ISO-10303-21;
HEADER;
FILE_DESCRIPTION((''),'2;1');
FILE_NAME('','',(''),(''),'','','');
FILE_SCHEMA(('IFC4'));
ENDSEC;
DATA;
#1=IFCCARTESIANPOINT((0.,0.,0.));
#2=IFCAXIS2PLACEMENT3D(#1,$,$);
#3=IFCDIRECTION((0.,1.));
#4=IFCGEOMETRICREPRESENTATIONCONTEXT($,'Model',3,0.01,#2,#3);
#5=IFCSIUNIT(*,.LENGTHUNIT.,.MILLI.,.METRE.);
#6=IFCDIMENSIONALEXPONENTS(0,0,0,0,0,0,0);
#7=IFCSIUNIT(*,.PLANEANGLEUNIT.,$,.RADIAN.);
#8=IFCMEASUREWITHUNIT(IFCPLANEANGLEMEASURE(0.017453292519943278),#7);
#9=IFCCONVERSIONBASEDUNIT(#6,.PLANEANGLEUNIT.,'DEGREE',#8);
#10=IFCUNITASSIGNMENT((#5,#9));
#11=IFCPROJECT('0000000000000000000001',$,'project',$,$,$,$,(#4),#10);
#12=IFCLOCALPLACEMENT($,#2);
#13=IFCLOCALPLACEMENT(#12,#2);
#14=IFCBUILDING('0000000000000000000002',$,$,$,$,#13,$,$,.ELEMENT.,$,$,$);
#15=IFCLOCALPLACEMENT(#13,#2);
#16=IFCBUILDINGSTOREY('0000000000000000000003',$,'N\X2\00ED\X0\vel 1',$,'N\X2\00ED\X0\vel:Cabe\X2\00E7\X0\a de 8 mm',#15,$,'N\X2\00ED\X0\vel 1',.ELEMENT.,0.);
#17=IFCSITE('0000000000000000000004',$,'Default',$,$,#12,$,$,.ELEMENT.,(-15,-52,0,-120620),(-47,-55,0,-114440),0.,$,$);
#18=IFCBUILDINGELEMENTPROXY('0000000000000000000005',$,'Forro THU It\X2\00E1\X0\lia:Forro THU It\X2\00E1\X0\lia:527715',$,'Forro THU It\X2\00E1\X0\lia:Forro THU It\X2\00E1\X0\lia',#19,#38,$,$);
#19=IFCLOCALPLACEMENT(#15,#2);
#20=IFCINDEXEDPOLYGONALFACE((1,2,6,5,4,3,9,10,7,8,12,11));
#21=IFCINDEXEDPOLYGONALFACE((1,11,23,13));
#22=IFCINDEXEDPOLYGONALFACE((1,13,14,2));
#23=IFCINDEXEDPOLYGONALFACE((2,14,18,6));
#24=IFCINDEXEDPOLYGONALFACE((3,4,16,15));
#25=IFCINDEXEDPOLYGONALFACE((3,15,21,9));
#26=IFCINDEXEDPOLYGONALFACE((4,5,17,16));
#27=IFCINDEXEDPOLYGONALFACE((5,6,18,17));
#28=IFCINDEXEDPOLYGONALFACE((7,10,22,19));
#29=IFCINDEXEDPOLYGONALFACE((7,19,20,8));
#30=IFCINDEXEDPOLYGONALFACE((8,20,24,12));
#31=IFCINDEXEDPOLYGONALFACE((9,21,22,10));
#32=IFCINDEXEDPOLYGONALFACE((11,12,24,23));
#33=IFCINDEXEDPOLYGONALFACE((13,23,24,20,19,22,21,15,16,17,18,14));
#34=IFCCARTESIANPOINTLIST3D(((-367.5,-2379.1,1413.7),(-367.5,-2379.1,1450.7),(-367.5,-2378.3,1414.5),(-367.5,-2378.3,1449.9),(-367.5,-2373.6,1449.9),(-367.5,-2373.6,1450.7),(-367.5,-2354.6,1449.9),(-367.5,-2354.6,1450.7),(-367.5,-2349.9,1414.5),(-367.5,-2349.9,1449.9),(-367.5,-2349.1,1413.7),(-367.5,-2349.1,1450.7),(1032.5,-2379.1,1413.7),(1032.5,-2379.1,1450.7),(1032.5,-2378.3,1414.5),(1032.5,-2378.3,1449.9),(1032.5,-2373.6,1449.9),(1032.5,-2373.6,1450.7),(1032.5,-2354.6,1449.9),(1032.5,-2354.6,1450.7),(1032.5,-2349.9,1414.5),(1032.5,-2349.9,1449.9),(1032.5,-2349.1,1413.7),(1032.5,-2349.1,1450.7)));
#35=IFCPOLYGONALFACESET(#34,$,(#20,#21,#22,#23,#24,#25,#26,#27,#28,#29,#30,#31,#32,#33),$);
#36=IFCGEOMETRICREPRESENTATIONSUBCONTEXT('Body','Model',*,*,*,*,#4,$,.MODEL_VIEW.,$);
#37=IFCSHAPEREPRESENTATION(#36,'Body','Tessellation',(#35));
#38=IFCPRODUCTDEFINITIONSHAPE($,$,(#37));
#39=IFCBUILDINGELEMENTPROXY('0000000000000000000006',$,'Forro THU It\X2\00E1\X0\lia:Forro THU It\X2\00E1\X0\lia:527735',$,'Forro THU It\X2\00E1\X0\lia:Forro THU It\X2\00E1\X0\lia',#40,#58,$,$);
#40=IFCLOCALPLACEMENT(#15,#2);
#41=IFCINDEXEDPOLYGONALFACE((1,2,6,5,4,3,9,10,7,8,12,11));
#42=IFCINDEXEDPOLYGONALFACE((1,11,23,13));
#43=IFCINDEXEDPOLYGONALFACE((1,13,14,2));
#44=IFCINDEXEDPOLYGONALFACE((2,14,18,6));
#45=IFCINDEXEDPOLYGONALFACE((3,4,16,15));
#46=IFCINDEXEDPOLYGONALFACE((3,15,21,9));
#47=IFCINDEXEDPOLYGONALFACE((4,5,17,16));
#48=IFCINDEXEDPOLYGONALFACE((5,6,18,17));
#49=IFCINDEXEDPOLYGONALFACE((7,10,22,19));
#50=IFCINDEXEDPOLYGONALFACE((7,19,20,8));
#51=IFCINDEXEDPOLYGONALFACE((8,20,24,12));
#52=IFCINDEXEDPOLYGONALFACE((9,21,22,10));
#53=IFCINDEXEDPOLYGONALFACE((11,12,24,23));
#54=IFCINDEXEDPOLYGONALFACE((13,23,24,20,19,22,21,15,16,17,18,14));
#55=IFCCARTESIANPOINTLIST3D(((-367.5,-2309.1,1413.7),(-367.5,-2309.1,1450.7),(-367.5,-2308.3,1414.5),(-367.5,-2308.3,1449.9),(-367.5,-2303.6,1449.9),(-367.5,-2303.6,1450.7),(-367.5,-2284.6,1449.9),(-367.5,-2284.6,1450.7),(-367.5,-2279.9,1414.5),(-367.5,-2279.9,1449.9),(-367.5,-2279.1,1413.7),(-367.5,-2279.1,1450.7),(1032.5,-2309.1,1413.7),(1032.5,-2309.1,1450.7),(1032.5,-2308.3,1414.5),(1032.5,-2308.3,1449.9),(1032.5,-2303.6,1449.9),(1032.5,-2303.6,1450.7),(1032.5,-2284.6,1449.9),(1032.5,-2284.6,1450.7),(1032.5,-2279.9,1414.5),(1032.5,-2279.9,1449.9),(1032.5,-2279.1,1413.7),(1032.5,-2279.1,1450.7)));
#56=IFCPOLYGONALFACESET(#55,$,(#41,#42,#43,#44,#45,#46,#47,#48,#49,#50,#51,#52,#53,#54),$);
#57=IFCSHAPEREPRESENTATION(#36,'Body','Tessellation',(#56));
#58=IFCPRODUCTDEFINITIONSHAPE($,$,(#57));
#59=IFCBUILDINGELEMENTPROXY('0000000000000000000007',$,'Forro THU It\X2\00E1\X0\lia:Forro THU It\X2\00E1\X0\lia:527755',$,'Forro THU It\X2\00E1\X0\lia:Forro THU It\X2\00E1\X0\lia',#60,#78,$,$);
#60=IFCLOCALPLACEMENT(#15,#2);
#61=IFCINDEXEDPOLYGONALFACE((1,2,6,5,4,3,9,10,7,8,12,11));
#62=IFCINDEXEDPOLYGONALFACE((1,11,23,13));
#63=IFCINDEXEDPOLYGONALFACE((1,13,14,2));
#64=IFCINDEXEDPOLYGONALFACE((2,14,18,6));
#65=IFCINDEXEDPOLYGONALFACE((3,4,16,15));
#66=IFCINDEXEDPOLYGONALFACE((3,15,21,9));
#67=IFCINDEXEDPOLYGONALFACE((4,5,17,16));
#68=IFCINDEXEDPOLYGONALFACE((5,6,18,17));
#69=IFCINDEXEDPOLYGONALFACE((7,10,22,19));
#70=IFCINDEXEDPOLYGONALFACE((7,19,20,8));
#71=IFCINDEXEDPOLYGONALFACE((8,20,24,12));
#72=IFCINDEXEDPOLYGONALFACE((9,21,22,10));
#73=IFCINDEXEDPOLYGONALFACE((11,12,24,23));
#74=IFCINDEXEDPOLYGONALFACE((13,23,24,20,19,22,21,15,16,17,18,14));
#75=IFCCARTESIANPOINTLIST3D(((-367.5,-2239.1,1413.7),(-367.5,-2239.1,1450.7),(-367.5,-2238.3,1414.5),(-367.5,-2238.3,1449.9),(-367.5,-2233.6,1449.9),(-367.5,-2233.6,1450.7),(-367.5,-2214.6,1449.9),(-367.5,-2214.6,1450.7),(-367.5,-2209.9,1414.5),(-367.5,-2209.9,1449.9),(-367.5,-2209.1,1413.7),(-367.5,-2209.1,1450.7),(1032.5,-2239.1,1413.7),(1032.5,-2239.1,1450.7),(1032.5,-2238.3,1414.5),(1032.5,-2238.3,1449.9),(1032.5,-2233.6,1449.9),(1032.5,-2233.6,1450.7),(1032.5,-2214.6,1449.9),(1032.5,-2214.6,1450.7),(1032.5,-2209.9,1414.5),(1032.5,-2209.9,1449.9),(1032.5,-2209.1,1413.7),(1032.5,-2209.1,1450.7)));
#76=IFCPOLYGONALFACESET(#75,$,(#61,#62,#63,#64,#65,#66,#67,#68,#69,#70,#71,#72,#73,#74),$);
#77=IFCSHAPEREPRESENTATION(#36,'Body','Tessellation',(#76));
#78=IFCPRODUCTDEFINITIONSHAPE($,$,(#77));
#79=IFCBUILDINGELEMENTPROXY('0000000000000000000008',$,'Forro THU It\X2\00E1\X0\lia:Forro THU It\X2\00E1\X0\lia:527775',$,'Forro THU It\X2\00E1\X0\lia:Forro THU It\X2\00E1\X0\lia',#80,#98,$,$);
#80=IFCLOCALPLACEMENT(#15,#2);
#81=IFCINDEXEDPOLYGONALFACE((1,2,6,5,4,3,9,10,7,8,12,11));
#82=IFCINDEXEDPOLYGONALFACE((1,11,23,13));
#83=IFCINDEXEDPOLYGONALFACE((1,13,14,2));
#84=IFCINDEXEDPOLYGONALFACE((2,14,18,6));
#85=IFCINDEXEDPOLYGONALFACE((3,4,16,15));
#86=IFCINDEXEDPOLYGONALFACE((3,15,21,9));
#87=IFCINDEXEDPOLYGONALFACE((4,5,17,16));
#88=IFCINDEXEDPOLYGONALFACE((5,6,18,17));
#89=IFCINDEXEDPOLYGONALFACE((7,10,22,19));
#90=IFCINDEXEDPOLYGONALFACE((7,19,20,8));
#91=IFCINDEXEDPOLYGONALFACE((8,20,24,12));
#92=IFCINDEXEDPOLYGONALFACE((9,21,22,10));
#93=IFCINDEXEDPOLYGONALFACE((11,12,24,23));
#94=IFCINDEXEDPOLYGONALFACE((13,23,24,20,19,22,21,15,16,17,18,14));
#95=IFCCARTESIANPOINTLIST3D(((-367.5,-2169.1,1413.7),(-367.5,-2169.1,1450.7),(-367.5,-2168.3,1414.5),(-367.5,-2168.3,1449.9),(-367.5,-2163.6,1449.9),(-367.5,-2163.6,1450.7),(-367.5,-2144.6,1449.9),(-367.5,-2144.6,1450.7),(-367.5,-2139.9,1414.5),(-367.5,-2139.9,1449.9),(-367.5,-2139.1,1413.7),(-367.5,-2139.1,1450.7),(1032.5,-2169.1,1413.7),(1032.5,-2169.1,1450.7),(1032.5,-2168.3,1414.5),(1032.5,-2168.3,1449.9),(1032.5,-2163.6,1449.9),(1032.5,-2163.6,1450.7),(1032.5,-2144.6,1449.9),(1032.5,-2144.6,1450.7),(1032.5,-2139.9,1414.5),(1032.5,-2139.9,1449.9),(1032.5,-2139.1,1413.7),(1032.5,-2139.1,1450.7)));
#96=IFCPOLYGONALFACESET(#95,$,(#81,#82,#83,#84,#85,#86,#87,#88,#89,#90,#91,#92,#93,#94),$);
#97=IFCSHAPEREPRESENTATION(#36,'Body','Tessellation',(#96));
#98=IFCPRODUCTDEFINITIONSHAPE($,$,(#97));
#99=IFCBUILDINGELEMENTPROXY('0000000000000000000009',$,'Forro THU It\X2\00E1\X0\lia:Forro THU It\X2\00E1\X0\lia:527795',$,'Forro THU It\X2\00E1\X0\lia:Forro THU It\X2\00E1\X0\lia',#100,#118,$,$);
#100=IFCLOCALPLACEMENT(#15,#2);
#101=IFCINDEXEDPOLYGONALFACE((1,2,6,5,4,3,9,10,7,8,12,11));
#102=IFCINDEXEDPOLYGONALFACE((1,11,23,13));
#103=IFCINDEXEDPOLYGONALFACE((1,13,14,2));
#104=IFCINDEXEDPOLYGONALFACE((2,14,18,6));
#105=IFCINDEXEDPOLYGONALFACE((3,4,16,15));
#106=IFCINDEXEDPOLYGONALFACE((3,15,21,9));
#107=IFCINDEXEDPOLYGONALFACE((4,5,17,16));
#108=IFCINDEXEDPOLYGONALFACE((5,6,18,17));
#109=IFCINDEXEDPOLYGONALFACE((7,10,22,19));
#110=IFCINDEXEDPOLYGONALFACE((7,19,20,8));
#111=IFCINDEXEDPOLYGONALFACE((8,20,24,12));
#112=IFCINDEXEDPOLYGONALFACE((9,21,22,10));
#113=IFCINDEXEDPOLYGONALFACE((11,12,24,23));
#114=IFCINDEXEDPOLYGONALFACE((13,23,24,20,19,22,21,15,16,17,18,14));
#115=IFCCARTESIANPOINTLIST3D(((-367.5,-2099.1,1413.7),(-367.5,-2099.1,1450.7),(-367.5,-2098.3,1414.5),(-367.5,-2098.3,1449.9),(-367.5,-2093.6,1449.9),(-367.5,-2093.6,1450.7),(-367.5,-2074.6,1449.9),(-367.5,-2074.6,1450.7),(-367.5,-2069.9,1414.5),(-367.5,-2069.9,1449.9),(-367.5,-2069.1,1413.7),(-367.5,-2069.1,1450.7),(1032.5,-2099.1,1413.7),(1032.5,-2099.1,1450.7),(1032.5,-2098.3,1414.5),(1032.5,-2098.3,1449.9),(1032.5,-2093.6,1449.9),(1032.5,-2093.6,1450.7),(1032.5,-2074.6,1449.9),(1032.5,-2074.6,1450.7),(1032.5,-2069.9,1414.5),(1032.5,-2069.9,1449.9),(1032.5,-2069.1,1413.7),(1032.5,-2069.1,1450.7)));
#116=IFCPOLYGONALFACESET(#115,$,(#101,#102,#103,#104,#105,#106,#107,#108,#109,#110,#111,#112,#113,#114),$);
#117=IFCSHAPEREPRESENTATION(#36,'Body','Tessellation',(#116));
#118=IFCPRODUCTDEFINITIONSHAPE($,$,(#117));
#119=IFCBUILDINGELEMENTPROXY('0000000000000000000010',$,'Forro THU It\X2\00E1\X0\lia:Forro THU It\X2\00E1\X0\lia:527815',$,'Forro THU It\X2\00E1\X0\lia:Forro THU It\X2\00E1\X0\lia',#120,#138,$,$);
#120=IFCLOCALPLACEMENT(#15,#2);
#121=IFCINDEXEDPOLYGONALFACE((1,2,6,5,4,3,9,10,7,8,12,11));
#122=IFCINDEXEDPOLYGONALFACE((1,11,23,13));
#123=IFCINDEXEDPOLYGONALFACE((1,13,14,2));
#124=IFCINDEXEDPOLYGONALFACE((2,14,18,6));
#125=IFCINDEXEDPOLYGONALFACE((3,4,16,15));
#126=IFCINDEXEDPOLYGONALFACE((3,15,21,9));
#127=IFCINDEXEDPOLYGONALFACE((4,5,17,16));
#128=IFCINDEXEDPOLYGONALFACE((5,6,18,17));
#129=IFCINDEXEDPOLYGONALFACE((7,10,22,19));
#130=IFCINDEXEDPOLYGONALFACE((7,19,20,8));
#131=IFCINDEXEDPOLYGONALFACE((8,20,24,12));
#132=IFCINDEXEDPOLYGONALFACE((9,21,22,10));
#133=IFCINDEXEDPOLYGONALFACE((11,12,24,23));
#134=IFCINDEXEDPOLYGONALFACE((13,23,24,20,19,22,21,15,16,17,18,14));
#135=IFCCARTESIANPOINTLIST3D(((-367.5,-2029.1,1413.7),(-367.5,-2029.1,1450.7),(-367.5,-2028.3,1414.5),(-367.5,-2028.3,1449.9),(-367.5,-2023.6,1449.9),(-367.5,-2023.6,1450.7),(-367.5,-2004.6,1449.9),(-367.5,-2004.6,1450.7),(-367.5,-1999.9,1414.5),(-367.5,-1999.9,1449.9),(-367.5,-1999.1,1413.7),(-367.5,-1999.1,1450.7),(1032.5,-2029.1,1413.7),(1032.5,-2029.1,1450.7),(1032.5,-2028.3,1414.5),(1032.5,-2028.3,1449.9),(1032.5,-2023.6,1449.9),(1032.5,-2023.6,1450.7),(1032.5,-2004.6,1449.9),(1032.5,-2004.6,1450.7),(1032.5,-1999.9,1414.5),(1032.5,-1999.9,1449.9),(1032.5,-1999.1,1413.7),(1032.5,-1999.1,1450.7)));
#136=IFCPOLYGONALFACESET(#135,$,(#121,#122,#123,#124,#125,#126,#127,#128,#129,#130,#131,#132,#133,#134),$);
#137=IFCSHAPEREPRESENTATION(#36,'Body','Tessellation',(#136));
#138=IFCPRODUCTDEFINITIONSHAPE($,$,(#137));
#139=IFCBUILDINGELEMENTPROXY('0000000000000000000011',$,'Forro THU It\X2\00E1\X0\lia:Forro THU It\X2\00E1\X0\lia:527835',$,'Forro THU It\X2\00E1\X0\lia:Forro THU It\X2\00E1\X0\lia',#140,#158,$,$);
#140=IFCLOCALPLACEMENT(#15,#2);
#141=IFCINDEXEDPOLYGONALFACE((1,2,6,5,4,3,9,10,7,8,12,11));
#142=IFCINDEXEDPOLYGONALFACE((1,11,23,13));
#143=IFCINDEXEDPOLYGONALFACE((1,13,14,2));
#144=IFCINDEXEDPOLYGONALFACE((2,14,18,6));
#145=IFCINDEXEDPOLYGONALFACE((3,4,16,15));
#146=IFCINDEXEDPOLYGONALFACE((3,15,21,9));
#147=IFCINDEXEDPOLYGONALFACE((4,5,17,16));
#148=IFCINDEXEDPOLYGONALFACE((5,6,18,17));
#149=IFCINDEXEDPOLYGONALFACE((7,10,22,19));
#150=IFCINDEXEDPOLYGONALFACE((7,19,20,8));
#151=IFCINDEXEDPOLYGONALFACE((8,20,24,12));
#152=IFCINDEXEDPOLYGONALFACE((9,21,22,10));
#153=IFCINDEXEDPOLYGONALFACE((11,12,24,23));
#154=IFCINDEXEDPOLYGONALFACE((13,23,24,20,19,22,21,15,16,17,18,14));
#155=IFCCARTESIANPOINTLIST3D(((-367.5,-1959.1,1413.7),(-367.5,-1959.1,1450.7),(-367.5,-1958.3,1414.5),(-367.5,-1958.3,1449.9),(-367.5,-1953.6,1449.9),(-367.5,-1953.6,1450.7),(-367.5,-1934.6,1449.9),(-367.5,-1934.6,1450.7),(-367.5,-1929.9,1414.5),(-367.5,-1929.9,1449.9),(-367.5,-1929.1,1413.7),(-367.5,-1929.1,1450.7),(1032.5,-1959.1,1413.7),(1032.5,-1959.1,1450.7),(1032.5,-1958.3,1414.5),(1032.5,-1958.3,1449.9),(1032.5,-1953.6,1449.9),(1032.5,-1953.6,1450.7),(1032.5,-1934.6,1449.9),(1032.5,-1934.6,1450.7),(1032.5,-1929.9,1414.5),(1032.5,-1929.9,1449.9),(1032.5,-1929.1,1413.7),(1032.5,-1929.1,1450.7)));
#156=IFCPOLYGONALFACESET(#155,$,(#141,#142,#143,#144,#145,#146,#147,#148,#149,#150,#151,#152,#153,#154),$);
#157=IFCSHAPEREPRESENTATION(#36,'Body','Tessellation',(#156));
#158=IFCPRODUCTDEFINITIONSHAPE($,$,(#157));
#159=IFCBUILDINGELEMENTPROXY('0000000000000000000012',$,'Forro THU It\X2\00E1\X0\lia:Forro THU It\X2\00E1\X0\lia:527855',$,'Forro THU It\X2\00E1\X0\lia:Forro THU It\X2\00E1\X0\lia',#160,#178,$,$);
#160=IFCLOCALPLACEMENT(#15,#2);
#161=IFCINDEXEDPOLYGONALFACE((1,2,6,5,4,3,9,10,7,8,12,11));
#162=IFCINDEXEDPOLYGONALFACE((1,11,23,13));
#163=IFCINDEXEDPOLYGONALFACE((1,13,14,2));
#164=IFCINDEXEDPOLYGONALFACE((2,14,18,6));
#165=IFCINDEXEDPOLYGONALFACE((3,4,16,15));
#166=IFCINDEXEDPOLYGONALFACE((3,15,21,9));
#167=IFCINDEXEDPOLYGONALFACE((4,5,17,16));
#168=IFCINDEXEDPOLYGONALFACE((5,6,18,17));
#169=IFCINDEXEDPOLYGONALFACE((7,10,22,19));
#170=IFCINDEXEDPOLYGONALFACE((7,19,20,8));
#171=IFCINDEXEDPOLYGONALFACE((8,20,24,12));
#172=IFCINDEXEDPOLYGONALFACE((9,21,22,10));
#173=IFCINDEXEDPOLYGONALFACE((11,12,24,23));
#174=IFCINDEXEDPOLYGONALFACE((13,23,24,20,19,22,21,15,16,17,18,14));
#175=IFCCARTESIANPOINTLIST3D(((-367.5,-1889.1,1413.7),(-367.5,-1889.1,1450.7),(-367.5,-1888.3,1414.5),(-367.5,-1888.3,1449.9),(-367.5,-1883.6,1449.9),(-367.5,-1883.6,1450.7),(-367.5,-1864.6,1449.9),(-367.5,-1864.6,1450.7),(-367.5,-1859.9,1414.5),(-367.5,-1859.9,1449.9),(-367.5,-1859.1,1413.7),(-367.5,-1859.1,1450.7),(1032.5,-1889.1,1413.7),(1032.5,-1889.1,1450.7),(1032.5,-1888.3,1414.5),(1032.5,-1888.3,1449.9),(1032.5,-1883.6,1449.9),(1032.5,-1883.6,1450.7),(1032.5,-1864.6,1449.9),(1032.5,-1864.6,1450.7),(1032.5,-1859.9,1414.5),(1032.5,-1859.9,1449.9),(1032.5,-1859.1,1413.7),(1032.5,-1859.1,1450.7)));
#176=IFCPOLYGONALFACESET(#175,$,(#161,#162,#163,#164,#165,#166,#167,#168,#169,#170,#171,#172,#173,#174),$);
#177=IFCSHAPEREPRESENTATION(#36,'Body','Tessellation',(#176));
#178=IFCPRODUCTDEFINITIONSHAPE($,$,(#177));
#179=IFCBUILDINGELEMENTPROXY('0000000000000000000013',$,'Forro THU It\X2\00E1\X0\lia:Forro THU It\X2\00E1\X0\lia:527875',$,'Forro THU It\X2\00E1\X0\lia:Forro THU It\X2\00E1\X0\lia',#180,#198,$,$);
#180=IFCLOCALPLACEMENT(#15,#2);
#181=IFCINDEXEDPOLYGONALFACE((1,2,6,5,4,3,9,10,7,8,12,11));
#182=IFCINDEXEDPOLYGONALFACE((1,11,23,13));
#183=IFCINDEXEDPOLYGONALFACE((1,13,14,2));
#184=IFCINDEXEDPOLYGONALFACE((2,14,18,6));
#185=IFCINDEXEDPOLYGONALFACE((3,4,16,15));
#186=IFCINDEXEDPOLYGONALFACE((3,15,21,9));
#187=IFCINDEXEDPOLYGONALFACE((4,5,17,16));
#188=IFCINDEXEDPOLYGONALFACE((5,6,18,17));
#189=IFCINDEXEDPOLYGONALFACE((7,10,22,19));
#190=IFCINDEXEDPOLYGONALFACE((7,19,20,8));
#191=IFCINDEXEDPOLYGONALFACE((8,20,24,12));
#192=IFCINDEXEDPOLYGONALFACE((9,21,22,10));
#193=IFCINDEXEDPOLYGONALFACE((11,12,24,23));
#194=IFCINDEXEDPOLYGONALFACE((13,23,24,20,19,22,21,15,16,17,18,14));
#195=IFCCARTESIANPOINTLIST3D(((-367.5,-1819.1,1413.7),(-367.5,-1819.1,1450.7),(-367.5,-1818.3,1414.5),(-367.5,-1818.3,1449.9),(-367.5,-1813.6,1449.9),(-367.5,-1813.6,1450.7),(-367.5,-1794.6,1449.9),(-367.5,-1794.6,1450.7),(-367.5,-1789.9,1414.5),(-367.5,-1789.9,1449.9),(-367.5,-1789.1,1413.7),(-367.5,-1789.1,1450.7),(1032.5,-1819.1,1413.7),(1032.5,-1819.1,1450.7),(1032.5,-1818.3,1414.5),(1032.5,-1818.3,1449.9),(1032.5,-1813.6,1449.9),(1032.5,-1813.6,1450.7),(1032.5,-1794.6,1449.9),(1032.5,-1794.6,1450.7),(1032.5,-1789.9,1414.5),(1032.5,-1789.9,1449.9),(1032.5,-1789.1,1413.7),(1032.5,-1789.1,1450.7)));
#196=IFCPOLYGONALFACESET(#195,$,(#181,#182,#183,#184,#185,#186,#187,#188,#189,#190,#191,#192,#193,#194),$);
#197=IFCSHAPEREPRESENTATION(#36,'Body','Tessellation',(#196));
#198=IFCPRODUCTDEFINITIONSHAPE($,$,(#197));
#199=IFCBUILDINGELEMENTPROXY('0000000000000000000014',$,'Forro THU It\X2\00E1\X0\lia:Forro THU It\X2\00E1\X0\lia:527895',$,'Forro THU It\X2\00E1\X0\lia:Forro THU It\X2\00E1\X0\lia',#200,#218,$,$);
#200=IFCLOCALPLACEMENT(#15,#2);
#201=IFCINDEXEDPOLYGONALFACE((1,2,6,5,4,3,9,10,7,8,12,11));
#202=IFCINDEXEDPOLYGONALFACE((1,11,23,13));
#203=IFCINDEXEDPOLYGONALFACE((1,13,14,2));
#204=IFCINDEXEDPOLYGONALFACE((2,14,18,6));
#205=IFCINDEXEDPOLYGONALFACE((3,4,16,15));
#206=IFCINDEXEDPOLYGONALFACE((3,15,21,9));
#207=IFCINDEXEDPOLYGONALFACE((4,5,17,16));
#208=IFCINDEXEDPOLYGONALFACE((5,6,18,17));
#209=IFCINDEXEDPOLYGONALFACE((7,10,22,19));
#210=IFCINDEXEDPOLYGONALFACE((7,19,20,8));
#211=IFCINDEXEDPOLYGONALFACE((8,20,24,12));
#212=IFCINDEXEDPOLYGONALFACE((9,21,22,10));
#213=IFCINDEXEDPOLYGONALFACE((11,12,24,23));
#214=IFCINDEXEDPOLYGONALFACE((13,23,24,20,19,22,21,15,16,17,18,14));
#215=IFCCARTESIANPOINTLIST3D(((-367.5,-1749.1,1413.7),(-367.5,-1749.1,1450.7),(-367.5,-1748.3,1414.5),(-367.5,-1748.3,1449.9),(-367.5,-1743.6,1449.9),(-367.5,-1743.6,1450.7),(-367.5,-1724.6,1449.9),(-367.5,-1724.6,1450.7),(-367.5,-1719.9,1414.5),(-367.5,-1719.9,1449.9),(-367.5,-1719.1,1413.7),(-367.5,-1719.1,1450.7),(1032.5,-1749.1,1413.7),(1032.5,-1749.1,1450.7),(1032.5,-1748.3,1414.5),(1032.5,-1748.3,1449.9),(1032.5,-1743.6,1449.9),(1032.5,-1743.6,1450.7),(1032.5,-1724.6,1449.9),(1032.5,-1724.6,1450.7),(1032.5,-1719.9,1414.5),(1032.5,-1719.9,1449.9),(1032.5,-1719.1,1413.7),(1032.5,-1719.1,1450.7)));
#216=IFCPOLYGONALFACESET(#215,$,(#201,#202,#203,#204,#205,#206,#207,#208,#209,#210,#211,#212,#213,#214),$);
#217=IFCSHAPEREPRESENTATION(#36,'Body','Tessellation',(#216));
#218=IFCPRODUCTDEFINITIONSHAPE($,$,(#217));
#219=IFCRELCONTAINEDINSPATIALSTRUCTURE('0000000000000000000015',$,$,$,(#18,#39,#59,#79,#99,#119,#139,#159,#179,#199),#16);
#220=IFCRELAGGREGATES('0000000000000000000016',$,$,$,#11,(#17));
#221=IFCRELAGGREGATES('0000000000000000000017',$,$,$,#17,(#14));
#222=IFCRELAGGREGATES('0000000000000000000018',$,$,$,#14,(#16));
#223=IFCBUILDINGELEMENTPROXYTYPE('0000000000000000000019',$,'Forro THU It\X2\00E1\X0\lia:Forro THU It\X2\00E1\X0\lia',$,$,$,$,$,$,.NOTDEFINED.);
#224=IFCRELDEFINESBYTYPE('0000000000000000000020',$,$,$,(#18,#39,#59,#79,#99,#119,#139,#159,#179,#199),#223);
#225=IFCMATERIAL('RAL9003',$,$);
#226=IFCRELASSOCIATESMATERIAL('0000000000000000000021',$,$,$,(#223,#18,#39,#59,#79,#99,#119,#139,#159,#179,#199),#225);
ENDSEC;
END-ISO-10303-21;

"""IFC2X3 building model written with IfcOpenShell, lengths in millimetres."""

from ifc_helpers import new_model, entity, si_unit, converted_unit, direction, frame, origin, place, context, subcontext, project, spatial, polyline, outline, extrude, source, transform, mapped, material, type_object, type_shapes, element, save


model = new_model("IFC2X3")

# Units and contexts
model_context = context("Model", 3, precision=0.01, world=origin(), true_north=direction((0.0, 1.0)))
body_context = subcontext(model_context, "Body", "Model", "MODEL_VIEW")
ifc_project = project(units=[si_unit("LENGTHUNIT", "METRE", prefix="MILLI"), converted_unit("PLANEANGLEUNIT", "DEGREE", entity("IfcPlaneAngleMeasure", 0.017453292519943278), si_unit("PLANEANGLEUNIT", "RADIAN"), dimensions=[0, 0, 0, 0, 0, 0, 0])], contexts=[model_context])

# Site, building, storey
site_placement = place(None, origin())
site = spatial("IfcSite", under=ifc_project, at=site_placement, Name="Default", CompositionType="ELEMENT", RefLatitude=(-15, -52, 0, -120620), RefLongitude=(-47, -55, 0, -114440), RefElevation=0.0)
building_placement = place(site_placement, origin())
building = spatial("IfcBuilding", under=site, at=building_placement, CompositionType="ELEMENT")
storey_placement = place(building_placement, origin())
storey = spatial("IfcBuildingStorey", under=building, at=storey_placement, Name="Nível 1", ObjectType="Nível:Cabeça de 8 mm", LongName="Nível 1", CompositionType="ELEMENT", Elevation=0.0)

# Building element proxies
ifc_material_1 = material(Name="RAL9003")
building_element_proxy_type = type_object("IfcBuildingElementProxyType", Name="Forro THU Itália:Forro THU Itália", PredefinedType="NOTDEFINED", material=ifc_material_1)
shared_shape_1 = source(origin(), body_context, "Body", "SweptSolid", [
    extrude(outline(polyline([(-12.5, -15.0), (24.5, -15.0), (24.5, 15.0), (-12.5, 15.0), (-12.5, 9.5), (-11.7, 9.5), (-11.7, 14.2), (23.7, 14.2), (23.7, -14.2), (-11.7, -14.2), (-11.7, -9.5), (-12.5, -9.5), (-12.5, -15.0)])), frame((0.0, 15.0, -12.5), z_axis=(1.0, 0.0, 0.0), x_axis=(0.0, 0.0, -1.0)), (0.0, 0.0, 1.0), 1400.0),
])
type_shapes(building_element_proxy_type, [shared_shape_1])
for number, where, name in (
    (1, (-367.5, -2379.1, 1450.7), "Forro THU Itália:Forro THU Itália:527715"),
    (2, (-367.5, -2309.1, 1450.7), "Forro THU Itália:Forro THU Itália:527735"),
    (3, (-367.5, -2239.1, 1450.7), "Forro THU Itália:Forro THU Itália:527755"),
    (4, (-367.5, -2169.1, 1450.7), "Forro THU Itália:Forro THU Itália:527775"),
    (5, (-367.5, -2099.1, 1450.7), "Forro THU Itália:Forro THU Itália:527795"),
    (6, (-367.5, -2029.1, 1450.7), "Forro THU Itália:Forro THU Itália:527815"),
    (7, (-367.5, -1959.1, 1450.7), "Forro THU Itália:Forro THU Itália:527835"),
    (8, (-367.5, -1889.1, 1450.7), "Forro THU Itália:Forro THU Itália:527855"),
    (9, (-367.5, -1819.1, 1450.7), "Forro THU Itália:Forro THU Itália:527875"),
    (10, (-367.5, -1749.1, 1450.7), "Forro THU Itália:Forro THU Itália:527895"),
):
    element("IfcBuildingElementProxy", number, at=place(storey_placement, frame(where)), inside=storey, type_object=building_element_proxy_type, material=ifc_material_1, Name=name, ObjectType="Forro THU Itália:Forro THU Itália", context=body_context, shape_type="MappedRepresentation", body=[
        mapped(shared_shape_1, transform((0.0, 0.0, 0.0), scale=1.0)),
    ])

save(model, "model.ifc")
